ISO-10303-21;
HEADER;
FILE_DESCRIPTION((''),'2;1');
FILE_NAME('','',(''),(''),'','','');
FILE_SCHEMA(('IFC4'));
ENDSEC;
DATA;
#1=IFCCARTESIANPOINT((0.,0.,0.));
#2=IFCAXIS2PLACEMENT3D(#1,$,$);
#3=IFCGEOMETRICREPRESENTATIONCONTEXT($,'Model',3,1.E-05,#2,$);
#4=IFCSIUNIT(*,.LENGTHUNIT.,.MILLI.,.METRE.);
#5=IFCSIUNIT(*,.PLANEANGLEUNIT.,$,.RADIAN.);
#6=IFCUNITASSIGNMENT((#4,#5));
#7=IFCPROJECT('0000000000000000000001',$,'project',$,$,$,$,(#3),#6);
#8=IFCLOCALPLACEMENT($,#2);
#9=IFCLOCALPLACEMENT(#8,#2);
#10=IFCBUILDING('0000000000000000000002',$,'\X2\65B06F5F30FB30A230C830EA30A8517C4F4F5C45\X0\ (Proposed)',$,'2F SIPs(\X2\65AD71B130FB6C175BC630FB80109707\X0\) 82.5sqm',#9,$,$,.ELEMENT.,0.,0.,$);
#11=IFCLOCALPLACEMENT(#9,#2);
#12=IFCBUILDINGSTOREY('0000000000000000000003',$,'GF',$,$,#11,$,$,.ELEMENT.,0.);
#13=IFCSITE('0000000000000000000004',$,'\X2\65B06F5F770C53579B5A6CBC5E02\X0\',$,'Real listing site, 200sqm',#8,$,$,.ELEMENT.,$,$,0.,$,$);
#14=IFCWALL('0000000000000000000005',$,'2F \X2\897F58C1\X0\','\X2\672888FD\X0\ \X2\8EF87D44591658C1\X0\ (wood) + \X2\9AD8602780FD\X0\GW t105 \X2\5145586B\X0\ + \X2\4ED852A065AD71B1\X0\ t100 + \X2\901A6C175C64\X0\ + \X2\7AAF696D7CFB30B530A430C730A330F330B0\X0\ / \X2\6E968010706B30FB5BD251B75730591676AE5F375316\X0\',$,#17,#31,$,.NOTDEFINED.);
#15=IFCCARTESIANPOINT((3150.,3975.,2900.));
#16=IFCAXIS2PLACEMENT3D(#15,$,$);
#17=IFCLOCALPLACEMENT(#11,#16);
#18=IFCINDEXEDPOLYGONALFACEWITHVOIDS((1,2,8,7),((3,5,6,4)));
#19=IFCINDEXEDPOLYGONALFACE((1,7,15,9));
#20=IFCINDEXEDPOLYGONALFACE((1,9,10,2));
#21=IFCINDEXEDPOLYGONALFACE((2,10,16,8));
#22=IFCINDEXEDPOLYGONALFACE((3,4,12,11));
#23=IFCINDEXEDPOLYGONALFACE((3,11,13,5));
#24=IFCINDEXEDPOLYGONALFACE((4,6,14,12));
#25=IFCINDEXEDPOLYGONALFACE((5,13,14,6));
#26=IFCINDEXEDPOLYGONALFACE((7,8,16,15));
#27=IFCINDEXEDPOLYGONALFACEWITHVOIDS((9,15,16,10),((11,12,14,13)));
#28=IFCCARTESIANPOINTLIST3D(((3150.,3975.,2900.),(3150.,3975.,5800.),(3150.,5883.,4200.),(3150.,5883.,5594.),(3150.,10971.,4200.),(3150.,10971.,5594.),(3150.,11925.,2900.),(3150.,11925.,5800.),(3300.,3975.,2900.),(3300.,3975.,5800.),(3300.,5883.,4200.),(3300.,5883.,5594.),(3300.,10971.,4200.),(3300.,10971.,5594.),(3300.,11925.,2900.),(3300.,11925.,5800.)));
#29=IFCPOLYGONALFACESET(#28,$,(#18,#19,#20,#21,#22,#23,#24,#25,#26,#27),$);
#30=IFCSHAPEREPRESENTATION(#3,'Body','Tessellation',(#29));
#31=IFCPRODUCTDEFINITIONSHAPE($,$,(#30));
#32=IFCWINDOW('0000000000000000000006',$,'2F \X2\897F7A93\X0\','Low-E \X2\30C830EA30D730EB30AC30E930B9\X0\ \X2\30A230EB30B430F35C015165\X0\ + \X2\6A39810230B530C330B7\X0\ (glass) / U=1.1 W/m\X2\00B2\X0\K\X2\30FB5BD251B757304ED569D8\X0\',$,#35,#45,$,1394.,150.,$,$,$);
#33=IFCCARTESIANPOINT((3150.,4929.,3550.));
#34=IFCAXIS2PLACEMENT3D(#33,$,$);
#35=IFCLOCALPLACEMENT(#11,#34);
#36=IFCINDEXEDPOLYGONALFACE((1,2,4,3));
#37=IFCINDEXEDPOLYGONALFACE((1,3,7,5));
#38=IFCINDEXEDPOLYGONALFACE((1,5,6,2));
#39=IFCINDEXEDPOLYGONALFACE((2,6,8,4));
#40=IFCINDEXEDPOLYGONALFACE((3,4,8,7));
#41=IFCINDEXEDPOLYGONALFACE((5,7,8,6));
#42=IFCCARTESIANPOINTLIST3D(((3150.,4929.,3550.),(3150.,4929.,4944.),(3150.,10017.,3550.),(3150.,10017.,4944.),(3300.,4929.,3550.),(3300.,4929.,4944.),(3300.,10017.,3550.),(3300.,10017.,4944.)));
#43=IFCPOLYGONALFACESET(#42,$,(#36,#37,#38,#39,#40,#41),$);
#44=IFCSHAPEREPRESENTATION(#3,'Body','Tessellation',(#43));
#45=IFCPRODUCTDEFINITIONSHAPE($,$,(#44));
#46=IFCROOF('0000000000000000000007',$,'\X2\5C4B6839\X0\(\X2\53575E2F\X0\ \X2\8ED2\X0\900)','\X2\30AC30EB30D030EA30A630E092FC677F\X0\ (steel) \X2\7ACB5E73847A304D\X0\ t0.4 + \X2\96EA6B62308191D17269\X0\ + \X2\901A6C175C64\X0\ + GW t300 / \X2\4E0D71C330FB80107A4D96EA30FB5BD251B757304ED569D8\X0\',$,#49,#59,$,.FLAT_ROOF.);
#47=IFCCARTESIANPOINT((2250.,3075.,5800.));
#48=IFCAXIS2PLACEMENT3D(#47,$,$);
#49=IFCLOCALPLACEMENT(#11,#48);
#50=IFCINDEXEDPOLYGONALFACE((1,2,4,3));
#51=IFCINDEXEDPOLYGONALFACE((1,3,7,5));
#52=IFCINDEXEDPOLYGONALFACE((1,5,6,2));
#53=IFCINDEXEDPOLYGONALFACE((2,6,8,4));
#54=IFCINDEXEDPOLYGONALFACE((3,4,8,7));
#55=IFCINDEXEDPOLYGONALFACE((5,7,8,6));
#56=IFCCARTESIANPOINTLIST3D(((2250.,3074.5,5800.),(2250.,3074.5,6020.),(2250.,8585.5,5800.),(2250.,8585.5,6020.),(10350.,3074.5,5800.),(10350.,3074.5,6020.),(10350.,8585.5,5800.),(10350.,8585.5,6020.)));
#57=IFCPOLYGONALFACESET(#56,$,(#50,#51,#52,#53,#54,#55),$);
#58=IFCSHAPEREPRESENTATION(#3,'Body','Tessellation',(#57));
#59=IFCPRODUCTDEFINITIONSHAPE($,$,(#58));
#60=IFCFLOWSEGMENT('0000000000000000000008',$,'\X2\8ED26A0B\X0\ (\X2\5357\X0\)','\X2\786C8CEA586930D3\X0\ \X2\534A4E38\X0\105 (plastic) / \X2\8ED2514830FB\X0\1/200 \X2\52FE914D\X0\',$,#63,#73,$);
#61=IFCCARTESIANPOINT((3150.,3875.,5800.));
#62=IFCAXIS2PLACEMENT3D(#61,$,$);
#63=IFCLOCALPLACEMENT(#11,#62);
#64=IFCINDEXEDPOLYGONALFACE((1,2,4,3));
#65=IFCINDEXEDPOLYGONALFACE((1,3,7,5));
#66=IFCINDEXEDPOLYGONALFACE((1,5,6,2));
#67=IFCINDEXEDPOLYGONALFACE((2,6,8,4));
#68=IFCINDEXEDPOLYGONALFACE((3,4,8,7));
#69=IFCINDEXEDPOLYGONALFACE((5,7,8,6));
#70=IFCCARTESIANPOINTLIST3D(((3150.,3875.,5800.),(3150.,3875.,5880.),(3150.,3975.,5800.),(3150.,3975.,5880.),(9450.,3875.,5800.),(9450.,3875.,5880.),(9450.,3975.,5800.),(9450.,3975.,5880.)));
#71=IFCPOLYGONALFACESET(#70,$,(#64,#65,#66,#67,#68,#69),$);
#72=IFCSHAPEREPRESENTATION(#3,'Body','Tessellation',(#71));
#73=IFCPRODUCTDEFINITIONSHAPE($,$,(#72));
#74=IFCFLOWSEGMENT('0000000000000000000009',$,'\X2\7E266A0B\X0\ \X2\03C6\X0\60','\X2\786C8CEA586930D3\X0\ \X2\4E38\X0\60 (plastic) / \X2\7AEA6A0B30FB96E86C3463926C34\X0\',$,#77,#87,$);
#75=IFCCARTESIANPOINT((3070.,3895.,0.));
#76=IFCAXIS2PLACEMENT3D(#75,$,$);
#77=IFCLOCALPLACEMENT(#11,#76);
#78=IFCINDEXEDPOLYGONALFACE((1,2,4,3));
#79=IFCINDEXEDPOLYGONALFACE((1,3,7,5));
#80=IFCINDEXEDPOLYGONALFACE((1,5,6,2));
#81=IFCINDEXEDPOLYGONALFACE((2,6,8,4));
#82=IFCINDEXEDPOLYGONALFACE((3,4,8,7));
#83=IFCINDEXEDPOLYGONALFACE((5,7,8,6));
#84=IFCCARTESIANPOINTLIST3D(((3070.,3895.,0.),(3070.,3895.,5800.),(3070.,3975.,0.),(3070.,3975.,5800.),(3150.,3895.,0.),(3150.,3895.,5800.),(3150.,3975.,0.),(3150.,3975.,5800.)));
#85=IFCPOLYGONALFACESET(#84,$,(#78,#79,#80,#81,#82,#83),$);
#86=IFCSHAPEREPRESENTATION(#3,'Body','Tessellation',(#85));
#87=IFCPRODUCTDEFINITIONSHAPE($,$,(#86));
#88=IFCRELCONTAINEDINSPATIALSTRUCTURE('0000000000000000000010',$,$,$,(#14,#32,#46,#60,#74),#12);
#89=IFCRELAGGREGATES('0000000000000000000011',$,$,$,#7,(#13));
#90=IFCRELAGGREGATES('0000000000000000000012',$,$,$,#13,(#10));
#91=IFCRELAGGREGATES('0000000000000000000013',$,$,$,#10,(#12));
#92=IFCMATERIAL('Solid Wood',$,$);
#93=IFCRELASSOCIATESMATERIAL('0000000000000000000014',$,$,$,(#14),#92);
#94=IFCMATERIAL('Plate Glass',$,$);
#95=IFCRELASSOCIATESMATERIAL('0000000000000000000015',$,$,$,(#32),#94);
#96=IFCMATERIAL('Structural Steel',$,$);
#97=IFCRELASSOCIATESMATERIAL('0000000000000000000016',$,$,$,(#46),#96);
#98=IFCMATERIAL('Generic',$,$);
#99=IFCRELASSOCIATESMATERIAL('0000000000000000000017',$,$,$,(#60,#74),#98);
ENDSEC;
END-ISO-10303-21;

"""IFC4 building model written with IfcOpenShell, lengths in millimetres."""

from ifc_helpers import new_model, si_unit, frame, frame_2d, origin, place, context, project, spatial, rectangle, extrude, material, element, fill, save


model = new_model("IFC4")

# Units and contexts
model_context = context("Model", 3, precision=1e-05, world=origin())
ifc_project = project(units=[si_unit("LENGTHUNIT", "METRE", prefix="MILLI"), si_unit("PLANEANGLEUNIT", "RADIAN")], contexts=[model_context])

# Site, building, storey
site_placement = place(None, origin())
site = spatial("IfcSite", under=ifc_project, at=site_placement, Name="新潟県南魚沼市", ObjectType="Real listing site, 200sqm", CompositionType="ELEMENT", RefElevation=0.0)
building_placement = place(site_placement, origin())
building = spatial("IfcBuilding", under=site, at=building_placement, Name="新潟・アトリエ兼住居 (Proposed)", ObjectType="2F SIPs(断熱・気密・耐震) 82.5sqm", CompositionType="ELEMENT", ElevationOfRefHeight=0.0, ElevationOfTerrain=0.0)
storey_placement = place(building_placement, origin())
storey = spatial("IfcBuildingStorey", under=building, at=storey_placement, Name="GF", CompositionType="ELEMENT", Elevation=0.0)

# Shared definitions
ifc_material_1 = material(Name="Solid Wood")

# Shared definitions
ifc_material_2 = material(Name="Plate Glass")

# Wall, opening, window
wall_1_placement = place(storey_placement, frame((3150.0, 3975.0, 2900.0)))
wall_1 = element("IfcWall", 1, at=wall_1_placement, inside=storey, material=ifc_material_1, Name="2F 西壁", Description="木製 軸組外壁 (wood) + 高性能GW t105 充填 + 付加断熱 t100 + 通気層 + 窯業系サイディング / 準耐火・寒冷地外皮強化", PredefinedType="NOTDEFINED", context=model_context, shape_type="SweptSolid", body=[
    extrude(rectangle(XDim=150.0, YDim=7950.0, at=frame_2d((75.0, 3975.0))), frame((3150.0, 3975.0, 2900.0)), (0.0, 0.0, 1.0), 2900.0),
])
opening_1_placement = place(storey_placement, frame((3150.0, 4929.0, 3550.0)))
opening_1 = element("IfcOpeningElement", 2, at=opening_1_placement, cuts=wall_1, PredefinedType="NOTDEFINED", context=model_context, shape_type="SweptSolid", body=[
    extrude(rectangle(XDim=150.0, YDim=5088.0, at=frame_2d((75.0, 2544.0))), frame((3150.0, 4929.0, 3550.0)), (0.0, 0.0, 1.0), 1394.0),
])
window_1_placement = place(storey_placement, frame((3150.0, 4929.0, 3550.0)))
window_1 = element("IfcWindow", 3, at=window_1_placement, inside=storey, material=ifc_material_2, Name="2F 西窓", Description="Low-E トリプルガラス アルゴン封入 + 樹脂サッシ (glass) / U=1.1 W/m²K・寒冷地仕様", OverallHeight=1394.0, OverallWidth=150.0, context=model_context, shape_type="SweptSolid", body=[
    extrude(rectangle(XDim=150.0, YDim=5088.0, at=frame_2d((75.0, 2544.0))), frame((3150.0, 4929.0, 3550.0)), (0.0, 0.0, 1.0), 1394.0),
])
fill(opening_1, window_1)

# Roof
ifc_material_3 = material(Name="Structural Steel")
for number, where, name in (
    (4, (2250.0, 3075.0, 5800.0), "屋根(南帯 軒900)"),
):
    element("IfcRoof", number, at=place(storey_placement, frame(where)), inside=storey, material=ifc_material_3, Name=name, Description="ガルバリウム鋼板 (steel) 立平葺き t0.4 + 雪止め金物 + 通気層 + GW t300 / 不燃・耐積雪・寒冷地仕様", PredefinedType="FLAT_ROOF", context=model_context, shape_type="SweptSolid", body=[
        extrude(rectangle(XDim=8100.0, YDim=5511.0, at=frame_2d((4050.0, 2755.0))), frame((2250.0, 3075.0, 5800.0)), (0.0, 0.0, 1.0), 220.0),
    ])

# Flow segments
ifc_material_4 = material(Name="Generic")
flow_segment_1_placement = place(storey_placement, frame((3150.0, 3875.0, 5800.0)))
element("IfcFlowSegment", 5, at=flow_segment_1_placement, inside=storey, material=ifc_material_4, Name="軒樋 (南)", Description="硬質塩ビ 半丸105 (plastic) / 軒先・1/200 勾配", context=model_context, shape_type="SweptSolid", body=[
    extrude(rectangle(XDim=6300.0, YDim=100.0, at=frame_2d((3150.0, 50.0))), frame((3150.0, 3875.0, 5800.0)), (0.0, 0.0, 1.0), 80.0),
])
flow_segment_2_placement = place(storey_placement, frame((3070.0, 3895.0, 0.0)))
element("IfcFlowSegment", 6, at=flow_segment_2_placement, inside=storey, material=ifc_material_4, Name="縦樋 φ60", Description="硬質塩ビ 丸60 (plastic) / 竪樋・雨水排水", context=model_context, shape_type="SweptSolid", body=[
    extrude(rectangle(XDim=80.0, YDim=80.0, at=frame_2d((40.0, 40.0))), frame((3070.0, 3895.0, 0.0)), (0.0, 0.0, 1.0), 5800.0),
])

save(model, "model.ifc")
